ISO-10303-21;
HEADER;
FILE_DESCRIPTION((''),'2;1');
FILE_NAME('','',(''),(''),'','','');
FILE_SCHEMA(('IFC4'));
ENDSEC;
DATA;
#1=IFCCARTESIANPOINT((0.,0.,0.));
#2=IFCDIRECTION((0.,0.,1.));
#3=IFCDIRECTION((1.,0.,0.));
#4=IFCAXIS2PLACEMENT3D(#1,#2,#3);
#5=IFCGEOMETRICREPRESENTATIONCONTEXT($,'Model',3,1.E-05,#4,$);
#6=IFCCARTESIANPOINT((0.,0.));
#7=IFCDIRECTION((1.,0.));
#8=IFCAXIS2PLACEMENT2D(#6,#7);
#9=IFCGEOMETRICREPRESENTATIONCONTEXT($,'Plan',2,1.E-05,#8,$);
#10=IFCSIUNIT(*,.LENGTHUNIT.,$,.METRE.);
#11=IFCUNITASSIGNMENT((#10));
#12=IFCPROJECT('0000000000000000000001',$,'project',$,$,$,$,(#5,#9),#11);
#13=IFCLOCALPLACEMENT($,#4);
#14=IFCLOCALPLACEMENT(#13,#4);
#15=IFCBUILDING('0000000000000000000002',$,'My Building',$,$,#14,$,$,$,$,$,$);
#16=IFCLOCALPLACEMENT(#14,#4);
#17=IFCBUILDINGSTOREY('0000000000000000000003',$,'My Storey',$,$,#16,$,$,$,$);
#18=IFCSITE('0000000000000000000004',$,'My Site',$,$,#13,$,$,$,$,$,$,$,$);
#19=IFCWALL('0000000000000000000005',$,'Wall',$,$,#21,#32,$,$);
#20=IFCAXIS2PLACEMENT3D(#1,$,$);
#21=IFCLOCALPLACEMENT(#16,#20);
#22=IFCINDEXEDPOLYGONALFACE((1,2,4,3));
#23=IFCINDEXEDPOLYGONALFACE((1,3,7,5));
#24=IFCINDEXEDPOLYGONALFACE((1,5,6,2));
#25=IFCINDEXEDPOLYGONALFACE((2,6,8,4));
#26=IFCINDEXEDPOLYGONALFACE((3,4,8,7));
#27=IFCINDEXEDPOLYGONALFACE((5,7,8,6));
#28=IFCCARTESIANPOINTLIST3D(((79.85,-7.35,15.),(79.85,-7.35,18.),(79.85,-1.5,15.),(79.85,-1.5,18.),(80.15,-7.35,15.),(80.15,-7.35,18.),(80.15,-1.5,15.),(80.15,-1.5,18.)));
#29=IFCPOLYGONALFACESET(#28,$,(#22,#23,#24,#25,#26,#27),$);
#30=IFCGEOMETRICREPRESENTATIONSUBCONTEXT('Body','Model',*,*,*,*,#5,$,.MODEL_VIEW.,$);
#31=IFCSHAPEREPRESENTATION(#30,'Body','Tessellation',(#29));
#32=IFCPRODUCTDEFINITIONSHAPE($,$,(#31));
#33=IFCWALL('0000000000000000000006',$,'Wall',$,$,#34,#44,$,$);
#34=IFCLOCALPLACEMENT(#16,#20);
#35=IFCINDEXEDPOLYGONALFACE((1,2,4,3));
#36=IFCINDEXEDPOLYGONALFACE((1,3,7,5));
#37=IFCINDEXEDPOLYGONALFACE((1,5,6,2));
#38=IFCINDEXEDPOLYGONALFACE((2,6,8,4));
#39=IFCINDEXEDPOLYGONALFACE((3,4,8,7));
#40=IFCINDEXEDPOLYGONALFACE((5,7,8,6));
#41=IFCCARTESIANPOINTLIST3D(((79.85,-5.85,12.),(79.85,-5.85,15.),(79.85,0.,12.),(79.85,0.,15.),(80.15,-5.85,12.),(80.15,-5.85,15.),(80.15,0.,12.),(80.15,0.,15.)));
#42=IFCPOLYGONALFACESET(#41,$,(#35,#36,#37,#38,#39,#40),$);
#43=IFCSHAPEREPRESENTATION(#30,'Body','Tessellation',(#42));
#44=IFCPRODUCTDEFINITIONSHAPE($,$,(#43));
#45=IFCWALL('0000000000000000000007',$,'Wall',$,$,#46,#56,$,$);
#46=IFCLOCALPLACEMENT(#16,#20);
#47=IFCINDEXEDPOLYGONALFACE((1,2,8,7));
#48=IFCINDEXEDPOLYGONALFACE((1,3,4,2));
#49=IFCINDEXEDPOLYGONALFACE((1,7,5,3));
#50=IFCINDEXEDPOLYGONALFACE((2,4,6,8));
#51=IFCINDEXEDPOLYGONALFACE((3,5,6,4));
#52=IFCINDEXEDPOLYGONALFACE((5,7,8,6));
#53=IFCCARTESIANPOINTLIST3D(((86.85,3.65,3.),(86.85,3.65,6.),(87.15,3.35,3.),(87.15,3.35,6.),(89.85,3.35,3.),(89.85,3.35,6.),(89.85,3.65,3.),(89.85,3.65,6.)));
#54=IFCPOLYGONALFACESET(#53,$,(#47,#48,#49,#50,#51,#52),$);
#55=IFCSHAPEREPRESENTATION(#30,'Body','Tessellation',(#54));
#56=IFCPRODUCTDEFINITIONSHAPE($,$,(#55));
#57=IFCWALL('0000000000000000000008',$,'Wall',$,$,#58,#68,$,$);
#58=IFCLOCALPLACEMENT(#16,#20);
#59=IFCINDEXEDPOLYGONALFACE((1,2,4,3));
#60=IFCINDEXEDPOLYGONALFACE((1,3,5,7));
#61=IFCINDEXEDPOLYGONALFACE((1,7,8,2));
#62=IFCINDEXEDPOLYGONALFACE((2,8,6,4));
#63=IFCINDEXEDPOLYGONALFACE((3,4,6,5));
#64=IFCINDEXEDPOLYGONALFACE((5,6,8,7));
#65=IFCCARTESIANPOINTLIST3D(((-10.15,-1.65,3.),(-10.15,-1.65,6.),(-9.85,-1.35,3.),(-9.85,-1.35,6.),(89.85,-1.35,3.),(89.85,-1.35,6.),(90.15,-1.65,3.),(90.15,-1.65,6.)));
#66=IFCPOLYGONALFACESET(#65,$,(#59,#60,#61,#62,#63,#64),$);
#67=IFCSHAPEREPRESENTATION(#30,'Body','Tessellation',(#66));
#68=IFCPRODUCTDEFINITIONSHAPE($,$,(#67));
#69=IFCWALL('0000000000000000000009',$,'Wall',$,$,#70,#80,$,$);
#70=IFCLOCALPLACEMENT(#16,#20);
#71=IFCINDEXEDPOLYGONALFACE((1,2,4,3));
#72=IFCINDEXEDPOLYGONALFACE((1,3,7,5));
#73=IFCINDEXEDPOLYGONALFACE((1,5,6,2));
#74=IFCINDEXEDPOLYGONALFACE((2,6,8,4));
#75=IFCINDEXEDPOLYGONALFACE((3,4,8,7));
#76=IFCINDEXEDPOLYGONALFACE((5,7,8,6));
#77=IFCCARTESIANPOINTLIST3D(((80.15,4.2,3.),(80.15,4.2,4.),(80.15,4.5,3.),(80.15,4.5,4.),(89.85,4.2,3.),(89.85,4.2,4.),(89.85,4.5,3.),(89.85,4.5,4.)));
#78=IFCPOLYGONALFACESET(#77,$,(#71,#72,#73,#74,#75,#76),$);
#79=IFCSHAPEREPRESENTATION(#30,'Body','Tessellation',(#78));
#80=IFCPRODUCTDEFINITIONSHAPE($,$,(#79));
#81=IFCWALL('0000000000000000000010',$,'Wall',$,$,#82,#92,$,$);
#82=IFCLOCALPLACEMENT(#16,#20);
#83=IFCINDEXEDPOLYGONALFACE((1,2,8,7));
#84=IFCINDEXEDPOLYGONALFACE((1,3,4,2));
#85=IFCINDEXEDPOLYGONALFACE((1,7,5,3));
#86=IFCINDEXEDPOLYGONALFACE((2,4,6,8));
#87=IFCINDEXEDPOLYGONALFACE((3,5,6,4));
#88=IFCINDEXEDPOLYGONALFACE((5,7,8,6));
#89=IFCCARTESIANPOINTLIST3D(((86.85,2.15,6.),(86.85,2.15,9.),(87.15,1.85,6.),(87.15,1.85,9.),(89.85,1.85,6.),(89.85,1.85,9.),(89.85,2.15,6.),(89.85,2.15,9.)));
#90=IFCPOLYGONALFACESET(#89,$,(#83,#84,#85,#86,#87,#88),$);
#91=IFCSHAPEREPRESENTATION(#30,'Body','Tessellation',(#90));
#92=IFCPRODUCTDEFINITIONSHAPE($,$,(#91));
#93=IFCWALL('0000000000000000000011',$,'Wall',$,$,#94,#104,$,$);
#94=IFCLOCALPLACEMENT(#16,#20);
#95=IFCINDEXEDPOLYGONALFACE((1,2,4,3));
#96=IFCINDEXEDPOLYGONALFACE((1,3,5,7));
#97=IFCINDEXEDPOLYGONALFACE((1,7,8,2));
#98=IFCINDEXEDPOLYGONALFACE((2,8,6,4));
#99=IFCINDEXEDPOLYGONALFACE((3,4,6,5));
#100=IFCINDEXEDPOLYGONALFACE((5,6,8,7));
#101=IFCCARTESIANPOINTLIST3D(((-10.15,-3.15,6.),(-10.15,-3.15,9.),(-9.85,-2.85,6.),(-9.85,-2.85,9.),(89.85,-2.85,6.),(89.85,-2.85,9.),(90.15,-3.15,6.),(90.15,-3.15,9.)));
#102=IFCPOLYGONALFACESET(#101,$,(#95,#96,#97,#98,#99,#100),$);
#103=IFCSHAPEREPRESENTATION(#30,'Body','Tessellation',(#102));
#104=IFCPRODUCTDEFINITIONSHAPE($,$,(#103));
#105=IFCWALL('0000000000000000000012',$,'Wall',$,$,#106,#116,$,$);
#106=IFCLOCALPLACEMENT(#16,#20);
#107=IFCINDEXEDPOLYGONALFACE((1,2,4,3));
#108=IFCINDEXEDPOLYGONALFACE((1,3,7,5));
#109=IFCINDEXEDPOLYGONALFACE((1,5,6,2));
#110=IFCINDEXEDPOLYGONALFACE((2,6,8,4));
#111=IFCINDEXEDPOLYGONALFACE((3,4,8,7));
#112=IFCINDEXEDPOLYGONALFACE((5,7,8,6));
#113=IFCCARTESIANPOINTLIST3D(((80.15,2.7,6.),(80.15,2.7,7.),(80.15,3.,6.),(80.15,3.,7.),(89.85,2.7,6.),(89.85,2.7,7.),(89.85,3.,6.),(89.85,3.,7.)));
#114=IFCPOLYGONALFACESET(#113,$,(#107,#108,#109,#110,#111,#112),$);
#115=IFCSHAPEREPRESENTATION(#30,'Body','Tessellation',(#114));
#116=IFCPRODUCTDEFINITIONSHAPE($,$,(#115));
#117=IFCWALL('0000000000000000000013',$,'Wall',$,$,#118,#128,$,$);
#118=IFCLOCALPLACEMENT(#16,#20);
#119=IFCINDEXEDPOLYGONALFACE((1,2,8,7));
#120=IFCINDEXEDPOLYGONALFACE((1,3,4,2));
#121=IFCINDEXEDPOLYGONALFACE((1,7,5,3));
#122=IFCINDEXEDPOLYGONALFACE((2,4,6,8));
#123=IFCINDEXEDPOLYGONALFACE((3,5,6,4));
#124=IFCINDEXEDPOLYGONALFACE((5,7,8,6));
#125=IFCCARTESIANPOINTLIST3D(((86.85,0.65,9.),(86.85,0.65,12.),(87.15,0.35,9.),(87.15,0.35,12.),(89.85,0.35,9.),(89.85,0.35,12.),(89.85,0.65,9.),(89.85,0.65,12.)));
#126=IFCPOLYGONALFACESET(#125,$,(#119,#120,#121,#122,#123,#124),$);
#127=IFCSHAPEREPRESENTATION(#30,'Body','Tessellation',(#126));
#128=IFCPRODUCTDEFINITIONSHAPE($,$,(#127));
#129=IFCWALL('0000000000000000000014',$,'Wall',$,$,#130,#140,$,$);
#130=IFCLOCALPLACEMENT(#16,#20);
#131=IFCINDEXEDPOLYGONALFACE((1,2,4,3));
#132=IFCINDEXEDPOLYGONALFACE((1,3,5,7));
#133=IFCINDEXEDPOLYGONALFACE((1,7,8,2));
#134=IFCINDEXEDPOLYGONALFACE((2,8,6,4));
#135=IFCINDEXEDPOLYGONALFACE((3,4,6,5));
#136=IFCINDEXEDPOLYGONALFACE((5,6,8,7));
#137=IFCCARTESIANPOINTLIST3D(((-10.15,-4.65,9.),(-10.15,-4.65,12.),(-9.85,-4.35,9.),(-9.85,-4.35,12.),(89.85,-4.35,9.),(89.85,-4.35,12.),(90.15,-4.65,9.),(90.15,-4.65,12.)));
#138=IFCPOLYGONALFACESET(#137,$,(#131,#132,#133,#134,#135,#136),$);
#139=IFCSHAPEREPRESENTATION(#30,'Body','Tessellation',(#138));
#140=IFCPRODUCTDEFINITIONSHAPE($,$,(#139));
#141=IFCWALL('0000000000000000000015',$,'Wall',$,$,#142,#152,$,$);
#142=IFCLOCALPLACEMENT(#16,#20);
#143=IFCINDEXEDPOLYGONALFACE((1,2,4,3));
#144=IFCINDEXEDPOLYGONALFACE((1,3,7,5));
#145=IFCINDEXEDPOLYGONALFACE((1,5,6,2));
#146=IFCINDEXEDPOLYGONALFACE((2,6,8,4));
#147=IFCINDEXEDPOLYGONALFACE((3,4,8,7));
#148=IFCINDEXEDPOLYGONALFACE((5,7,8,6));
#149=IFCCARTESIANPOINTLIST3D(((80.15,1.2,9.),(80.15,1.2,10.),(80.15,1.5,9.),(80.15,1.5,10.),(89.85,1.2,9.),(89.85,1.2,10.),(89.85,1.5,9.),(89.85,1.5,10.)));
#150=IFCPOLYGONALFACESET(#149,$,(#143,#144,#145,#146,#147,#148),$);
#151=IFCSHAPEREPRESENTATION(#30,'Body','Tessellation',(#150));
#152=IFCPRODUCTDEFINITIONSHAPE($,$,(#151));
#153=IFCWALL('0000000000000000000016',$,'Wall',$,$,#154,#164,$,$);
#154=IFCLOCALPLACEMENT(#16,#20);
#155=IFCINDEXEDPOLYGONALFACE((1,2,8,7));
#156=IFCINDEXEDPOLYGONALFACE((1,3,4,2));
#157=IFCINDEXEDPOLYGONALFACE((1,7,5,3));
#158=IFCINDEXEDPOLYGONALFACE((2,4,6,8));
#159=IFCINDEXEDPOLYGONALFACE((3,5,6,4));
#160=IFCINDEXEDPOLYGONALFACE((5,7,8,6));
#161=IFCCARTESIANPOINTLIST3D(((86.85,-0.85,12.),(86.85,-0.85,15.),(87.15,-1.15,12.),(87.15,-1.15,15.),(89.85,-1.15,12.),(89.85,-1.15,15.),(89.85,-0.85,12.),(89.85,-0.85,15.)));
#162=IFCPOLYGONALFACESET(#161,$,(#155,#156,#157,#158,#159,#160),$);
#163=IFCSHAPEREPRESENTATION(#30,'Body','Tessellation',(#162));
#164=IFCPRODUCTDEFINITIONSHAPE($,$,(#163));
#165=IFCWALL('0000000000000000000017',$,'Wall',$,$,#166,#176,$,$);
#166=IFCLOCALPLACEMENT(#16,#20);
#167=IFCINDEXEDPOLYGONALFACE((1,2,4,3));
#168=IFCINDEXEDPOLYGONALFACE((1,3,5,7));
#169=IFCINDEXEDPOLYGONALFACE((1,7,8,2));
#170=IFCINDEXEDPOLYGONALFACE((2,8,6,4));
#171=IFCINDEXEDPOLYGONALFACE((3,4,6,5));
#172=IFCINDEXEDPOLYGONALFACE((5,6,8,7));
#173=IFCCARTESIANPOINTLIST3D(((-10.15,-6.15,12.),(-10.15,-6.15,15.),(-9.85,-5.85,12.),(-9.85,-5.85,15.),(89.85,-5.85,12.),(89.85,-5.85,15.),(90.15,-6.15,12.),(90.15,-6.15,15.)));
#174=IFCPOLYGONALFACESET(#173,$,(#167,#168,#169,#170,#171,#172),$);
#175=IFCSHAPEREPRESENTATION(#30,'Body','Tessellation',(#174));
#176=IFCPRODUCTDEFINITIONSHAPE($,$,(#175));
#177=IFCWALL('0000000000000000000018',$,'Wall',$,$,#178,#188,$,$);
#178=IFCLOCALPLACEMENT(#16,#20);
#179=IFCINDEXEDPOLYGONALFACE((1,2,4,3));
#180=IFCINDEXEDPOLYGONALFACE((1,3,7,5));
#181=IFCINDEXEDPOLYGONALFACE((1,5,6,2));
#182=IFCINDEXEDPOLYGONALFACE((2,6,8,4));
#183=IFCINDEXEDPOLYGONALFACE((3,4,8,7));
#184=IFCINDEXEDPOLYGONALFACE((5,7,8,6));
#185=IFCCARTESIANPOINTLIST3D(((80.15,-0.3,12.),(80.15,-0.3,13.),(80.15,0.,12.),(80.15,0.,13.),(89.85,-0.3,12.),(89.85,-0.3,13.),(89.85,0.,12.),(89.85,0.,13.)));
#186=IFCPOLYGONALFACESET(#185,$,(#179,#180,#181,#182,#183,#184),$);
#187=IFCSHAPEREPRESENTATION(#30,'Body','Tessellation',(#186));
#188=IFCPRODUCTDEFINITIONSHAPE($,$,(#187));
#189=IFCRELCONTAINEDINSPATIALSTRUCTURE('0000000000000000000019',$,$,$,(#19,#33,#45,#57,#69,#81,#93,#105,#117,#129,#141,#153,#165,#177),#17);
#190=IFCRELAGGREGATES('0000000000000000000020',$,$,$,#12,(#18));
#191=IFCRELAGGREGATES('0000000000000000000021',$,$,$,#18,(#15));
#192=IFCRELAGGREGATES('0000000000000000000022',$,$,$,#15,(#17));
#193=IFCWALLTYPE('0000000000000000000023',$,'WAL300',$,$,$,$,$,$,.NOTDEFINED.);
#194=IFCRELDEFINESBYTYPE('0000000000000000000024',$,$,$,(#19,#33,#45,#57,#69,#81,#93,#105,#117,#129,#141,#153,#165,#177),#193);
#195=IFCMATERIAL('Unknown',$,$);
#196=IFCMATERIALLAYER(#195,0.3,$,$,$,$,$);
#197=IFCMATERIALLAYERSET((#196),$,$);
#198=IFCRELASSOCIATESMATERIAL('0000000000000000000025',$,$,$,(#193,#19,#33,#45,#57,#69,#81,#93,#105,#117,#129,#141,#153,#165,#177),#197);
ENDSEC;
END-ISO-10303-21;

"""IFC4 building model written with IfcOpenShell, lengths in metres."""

from ifc_helpers import new_model, si_unit, frame, origin_with_axes, origin_2d_with_axis, place, context, subcontext, project, spatial, line, indexed_curve, outline, extrude, material, layer, layer_set, layer_usage, type_object, element, save


model = new_model("IFC4")

# Units and contexts
model_context = context("Model", 3, precision=1e-05, world=origin_with_axes())
plan_context = context("Plan", 2, precision=1e-05, world=origin_2d_with_axis())
body_context = subcontext(model_context, "Body", "Model", "MODEL_VIEW")
ifc_project = project(units=[si_unit("LENGTHUNIT", "METRE")], contexts=[model_context, plan_context])

# Site, building, storey
site_placement = place(None, origin_with_axes())
site = spatial("IfcSite", under=ifc_project, at=site_placement, Name="My Site")
building_placement = place(site_placement, origin_with_axes())
building = spatial("IfcBuilding", under=site, at=building_placement, Name="My Building")
storey_placement = place(building_placement, origin_with_axes())
storey = spatial("IfcBuildingStorey", under=building, at=storey_placement, Name="My Storey")

# Walls
ifc_material = material(Name="Unknown")
ifc_layer = layer(ifc_material, 0.3)
ifc_layer_set = layer_set([ifc_layer])
wall_type = type_object("IfcWallType", Name="WAL300", PredefinedType="NOTDEFINED", material=ifc_layer_set)
ifc_layer_usage_1 = layer_usage(ifc_layer_set, "AXIS2", "POSITIVE", -0.15)
wall_1_placement = place(storey_placement, frame((80.0, -7.5, 15.0), z_axis=(0.0, 0.0, 1.0), x_axis=(0.0, 1.0, 0.0)))
element("IfcWall", 1, at=wall_1_placement, inside=storey, type_object=wall_type, material=ifc_layer_usage_1, Name="Wall", context=body_context, shape_type="SweptSolid", body=[
    extrude(outline(indexed_curve([(0.15, -0.15), (0.15, 0.15), (6.0, 0.15), (6.0, -0.15)], segments=[line(1, 2, 3, 4, 1)])), origin_with_axes(), (0.0, 0.0, 1.0), 3.0),
])
ifc_layer_usage_2 = layer_usage(ifc_layer_set, "AXIS2", "POSITIVE", -0.15)
wall_2_placement = place(storey_placement, frame((80.0, -6.0, 12.0), z_axis=(0.0, 0.0, 1.0), x_axis=(0.0, 1.0, 0.0)))
element("IfcWall", 2, at=wall_2_placement, inside=storey, type_object=wall_type, material=ifc_layer_usage_2, Name="Wall", context=body_context, shape_type="SweptSolid", body=[
    extrude(outline(indexed_curve([(0.15, -0.15), (0.15, 0.15), (6.0, 0.15), (6.0, -0.15)], segments=[line(1, 2, 3, 4, 1)])), origin_with_axes(), (0.0, 0.0, 1.0), 3.0),
])
ifc_layer_usage_3 = layer_usage(ifc_layer_set, "AXIS2", "POSITIVE", -0.15)
wall_3_placement = place(storey_placement, frame((87.0, 3.5, 3.0), z_axis=(0.0, 0.0, 1.0), x_axis=(1.0, 0.0, 0.0)))
element("IfcWall", 3, at=wall_3_placement, inside=storey, type_object=wall_type, material=ifc_layer_usage_3, Name="Wall", context=body_context, shape_type="SweptSolid", body=[
    extrude(outline(indexed_curve([(0.15, -0.15), (-0.15, 0.15), (2.85, 0.15), (2.85, -0.15)], segments=[line(1, 2, 3, 4, 1)])), origin_with_axes(), (0.0, 0.0, 1.0), 3.0),
])
ifc_layer_usage_4 = layer_usage(ifc_layer_set, "AXIS2", "POSITIVE", -0.15)
wall_4_placement = place(storey_placement, frame((90.0, -1.5, 3.0), z_axis=(0.0, 0.0, 1.0), x_axis=(-1.0, 0.0, 0.0)))
element("IfcWall", 4, at=wall_4_placement, inside=storey, type_object=wall_type, material=ifc_layer_usage_4, Name="Wall", context=body_context, shape_type="SweptSolid", body=[
    extrude(outline(indexed_curve([(0.15, -0.15), (-0.15, 0.15), (100.15, 0.15), (99.85, -0.15)], segments=[line(1, 2, 3, 4, 1)])), origin_with_axes(), (0.0, 0.0, 1.0), 3.0),
])
ifc_layer_usage_5 = layer_usage(ifc_layer_set, "AXIS2", "POSITIVE", -0.3)
wall_5_placement = place(storey_placement, frame((80.15, 4.5, 3.0), z_axis=(0.0, 0.0, 1.0), x_axis=(1.0, 0.0, 0.0)))
element("IfcWall", 5, at=wall_5_placement, inside=storey, type_object=wall_type, material=ifc_layer_usage_5, Name="Wall", context=body_context, shape_type="SweptSolid", body=[
    extrude(outline(indexed_curve([(0.0, -0.3), (0.0, 0.0), (9.7, 0.0), (9.7, -0.3)], segments=[line(1, 2, 3, 4, 1)])), origin_with_axes(), (0.0, 0.0, 1.0), 1.0),
])
ifc_layer_usage_6 = layer_usage(ifc_layer_set, "AXIS2", "POSITIVE", -0.15)
wall_6_placement = place(storey_placement, frame((87.0, 2.0, 6.0), z_axis=(0.0, 0.0, 1.0), x_axis=(1.0, 0.0, 0.0)))
element("IfcWall", 6, at=wall_6_placement, inside=storey, type_object=wall_type, material=ifc_layer_usage_6, Name="Wall", context=body_context, shape_type="SweptSolid", body=[
    extrude(outline(indexed_curve([(0.15, -0.15), (-0.15, 0.15), (2.85, 0.15), (2.85, -0.15)], segments=[line(1, 2, 3, 4, 1)])), origin_with_axes(), (0.0, 0.0, 1.0), 3.0),
])
ifc_layer_usage_7 = layer_usage(ifc_layer_set, "AXIS2", "POSITIVE", -0.15)
wall_7_placement = place(storey_placement, frame((90.0, -3.0, 6.0), z_axis=(0.0, 0.0, 1.0), x_axis=(-1.0, 0.0, 0.0)))
element("IfcWall", 7, at=wall_7_placement, inside=storey, type_object=wall_type, material=ifc_layer_usage_7, Name="Wall", context=body_context, shape_type="SweptSolid", body=[
    extrude(outline(indexed_curve([(0.15, -0.15), (-0.15, 0.15), (100.15, 0.15), (99.85, -0.15)], segments=[line(1, 2, 3, 4, 1)])), origin_with_axes(), (0.0, 0.0, 1.0), 3.0),
])
ifc_layer_usage_8 = layer_usage(ifc_layer_set, "AXIS2", "POSITIVE", -0.3)
wall_8_placement = place(storey_placement, frame((80.15, 3.0, 6.0), z_axis=(0.0, 0.0, 1.0), x_axis=(1.0, 0.0, 0.0)))
element("IfcWall", 8, at=wall_8_placement, inside=storey, type_object=wall_type, material=ifc_layer_usage_8, Name="Wall", context=body_context, shape_type="SweptSolid", body=[
    extrude(outline(indexed_curve([(0.0, -0.3), (0.0, 0.0), (9.7, 0.0), (9.7, -0.3)], segments=[line(1, 2, 3, 4, 1)])), origin_with_axes(), (0.0, 0.0, 1.0), 1.0),
])
ifc_layer_usage_9 = layer_usage(ifc_layer_set, "AXIS2", "POSITIVE", -0.15)
wall_9_placement = place(storey_placement, frame((87.0, 0.5, 9.0), z_axis=(0.0, 0.0, 1.0), x_axis=(1.0, 0.0, 0.0)))
element("IfcWall", 9, at=wall_9_placement, inside=storey, type_object=wall_type, material=ifc_layer_usage_9, Name="Wall", context=body_context, shape_type="SweptSolid", body=[
    extrude(outline(indexed_curve([(0.15, -0.15), (-0.15, 0.15), (2.85, 0.15), (2.85, -0.15)], segments=[line(1, 2, 3, 4, 1)])), origin_with_axes(), (0.0, 0.0, 1.0), 3.0),
])
ifc_layer_usage_10 = layer_usage(ifc_layer_set, "AXIS2", "POSITIVE", -0.15)
wall_10_placement = place(storey_placement, frame((90.0, -4.5, 9.0), z_axis=(0.0, 0.0, 1.0), x_axis=(-1.0, 0.0, 0.0)))
element("IfcWall", 10, at=wall_10_placement, inside=storey, type_object=wall_type, material=ifc_layer_usage_10, Name="Wall", context=body_context, shape_type="SweptSolid", body=[
    extrude(outline(indexed_curve([(0.15, -0.15), (-0.15, 0.15), (100.15, 0.15), (99.85, -0.15)], segments=[line(1, 2, 3, 4, 1)])), origin_with_axes(), (0.0, 0.0, 1.0), 3.0),
])
ifc_layer_usage_11 = layer_usage(ifc_layer_set, "AXIS2", "POSITIVE", -0.3)
wall_11_placement = place(storey_placement, frame((80.15, 1.5, 9.0), z_axis=(0.0, 0.0, 1.0), x_axis=(1.0, 0.0, 0.0)))
element("IfcWall", 11, at=wall_11_placement, inside=storey, type_object=wall_type, material=ifc_layer_usage_11, Name="Wall", context=body_context, shape_type="SweptSolid", body=[
    extrude(outline(indexed_curve([(0.0, -0.3), (0.0, 0.0), (9.7, 0.0), (9.7, -0.3)], segments=[line(1, 2, 3, 4, 1)])), origin_with_axes(), (0.0, 0.0, 1.0), 1.0),
])
ifc_layer_usage_12 = layer_usage(ifc_layer_set, "AXIS2", "POSITIVE", -0.15)
wall_12_placement = place(storey_placement, frame((87.0, -1.0, 12.0), z_axis=(0.0, 0.0, 1.0), x_axis=(1.0, 0.0, 0.0)))
element("IfcWall", 12, at=wall_12_placement, inside=storey, type_object=wall_type, material=ifc_layer_usage_12, Name="Wall", context=body_context, shape_type="SweptSolid", body=[
    extrude(outline(indexed_curve([(0.15, -0.15), (-0.15, 0.15), (2.85, 0.15), (2.85, -0.15)], segments=[line(1, 2, 3, 4, 1)])), origin_with_axes(), (0.0, 0.0, 1.0), 3.0),
])
ifc_layer_usage_13 = layer_usage(ifc_layer_set, "AXIS2", "POSITIVE", -0.15)
wall_13_placement = place(storey_placement, frame((90.0, -6.0, 12.0), z_axis=(0.0, 0.0, 1.0), x_axis=(-1.0, 0.0, 0.0)))
element("IfcWall", 13, at=wall_13_placement, inside=storey, type_object=wall_type, material=ifc_layer_usage_13, Name="Wall", context=body_context, shape_type="SweptSolid", body=[
    extrude(outline(indexed_curve([(0.15, -0.15), (-0.15, 0.15), (100.15, 0.15), (99.85, -0.15)], segments=[line(1, 2, 3, 4, 1)])), origin_with_axes(), (0.0, 0.0, 1.0), 3.0),
])
ifc_layer_usage_14 = layer_usage(ifc_layer_set, "AXIS2", "POSITIVE", -0.3)
wall_14_placement = place(storey_placement, frame((80.15, 0.0, 12.0), z_axis=(0.0, 0.0, 1.0), x_axis=(1.0, 0.0, 0.0)))
element("IfcWall", 14, at=wall_14_placement, inside=storey, type_object=wall_type, material=ifc_layer_usage_14, Name="Wall", context=body_context, shape_type="SweptSolid", body=[
    extrude(outline(indexed_curve([(0.0, -0.3), (0.0, 0.0), (9.7, 0.0), (9.7, -0.3)], segments=[line(1, 2, 3, 4, 1)])), origin_with_axes(), (0.0, 0.0, 1.0), 1.0),
])

save(model, "model.ifc")
